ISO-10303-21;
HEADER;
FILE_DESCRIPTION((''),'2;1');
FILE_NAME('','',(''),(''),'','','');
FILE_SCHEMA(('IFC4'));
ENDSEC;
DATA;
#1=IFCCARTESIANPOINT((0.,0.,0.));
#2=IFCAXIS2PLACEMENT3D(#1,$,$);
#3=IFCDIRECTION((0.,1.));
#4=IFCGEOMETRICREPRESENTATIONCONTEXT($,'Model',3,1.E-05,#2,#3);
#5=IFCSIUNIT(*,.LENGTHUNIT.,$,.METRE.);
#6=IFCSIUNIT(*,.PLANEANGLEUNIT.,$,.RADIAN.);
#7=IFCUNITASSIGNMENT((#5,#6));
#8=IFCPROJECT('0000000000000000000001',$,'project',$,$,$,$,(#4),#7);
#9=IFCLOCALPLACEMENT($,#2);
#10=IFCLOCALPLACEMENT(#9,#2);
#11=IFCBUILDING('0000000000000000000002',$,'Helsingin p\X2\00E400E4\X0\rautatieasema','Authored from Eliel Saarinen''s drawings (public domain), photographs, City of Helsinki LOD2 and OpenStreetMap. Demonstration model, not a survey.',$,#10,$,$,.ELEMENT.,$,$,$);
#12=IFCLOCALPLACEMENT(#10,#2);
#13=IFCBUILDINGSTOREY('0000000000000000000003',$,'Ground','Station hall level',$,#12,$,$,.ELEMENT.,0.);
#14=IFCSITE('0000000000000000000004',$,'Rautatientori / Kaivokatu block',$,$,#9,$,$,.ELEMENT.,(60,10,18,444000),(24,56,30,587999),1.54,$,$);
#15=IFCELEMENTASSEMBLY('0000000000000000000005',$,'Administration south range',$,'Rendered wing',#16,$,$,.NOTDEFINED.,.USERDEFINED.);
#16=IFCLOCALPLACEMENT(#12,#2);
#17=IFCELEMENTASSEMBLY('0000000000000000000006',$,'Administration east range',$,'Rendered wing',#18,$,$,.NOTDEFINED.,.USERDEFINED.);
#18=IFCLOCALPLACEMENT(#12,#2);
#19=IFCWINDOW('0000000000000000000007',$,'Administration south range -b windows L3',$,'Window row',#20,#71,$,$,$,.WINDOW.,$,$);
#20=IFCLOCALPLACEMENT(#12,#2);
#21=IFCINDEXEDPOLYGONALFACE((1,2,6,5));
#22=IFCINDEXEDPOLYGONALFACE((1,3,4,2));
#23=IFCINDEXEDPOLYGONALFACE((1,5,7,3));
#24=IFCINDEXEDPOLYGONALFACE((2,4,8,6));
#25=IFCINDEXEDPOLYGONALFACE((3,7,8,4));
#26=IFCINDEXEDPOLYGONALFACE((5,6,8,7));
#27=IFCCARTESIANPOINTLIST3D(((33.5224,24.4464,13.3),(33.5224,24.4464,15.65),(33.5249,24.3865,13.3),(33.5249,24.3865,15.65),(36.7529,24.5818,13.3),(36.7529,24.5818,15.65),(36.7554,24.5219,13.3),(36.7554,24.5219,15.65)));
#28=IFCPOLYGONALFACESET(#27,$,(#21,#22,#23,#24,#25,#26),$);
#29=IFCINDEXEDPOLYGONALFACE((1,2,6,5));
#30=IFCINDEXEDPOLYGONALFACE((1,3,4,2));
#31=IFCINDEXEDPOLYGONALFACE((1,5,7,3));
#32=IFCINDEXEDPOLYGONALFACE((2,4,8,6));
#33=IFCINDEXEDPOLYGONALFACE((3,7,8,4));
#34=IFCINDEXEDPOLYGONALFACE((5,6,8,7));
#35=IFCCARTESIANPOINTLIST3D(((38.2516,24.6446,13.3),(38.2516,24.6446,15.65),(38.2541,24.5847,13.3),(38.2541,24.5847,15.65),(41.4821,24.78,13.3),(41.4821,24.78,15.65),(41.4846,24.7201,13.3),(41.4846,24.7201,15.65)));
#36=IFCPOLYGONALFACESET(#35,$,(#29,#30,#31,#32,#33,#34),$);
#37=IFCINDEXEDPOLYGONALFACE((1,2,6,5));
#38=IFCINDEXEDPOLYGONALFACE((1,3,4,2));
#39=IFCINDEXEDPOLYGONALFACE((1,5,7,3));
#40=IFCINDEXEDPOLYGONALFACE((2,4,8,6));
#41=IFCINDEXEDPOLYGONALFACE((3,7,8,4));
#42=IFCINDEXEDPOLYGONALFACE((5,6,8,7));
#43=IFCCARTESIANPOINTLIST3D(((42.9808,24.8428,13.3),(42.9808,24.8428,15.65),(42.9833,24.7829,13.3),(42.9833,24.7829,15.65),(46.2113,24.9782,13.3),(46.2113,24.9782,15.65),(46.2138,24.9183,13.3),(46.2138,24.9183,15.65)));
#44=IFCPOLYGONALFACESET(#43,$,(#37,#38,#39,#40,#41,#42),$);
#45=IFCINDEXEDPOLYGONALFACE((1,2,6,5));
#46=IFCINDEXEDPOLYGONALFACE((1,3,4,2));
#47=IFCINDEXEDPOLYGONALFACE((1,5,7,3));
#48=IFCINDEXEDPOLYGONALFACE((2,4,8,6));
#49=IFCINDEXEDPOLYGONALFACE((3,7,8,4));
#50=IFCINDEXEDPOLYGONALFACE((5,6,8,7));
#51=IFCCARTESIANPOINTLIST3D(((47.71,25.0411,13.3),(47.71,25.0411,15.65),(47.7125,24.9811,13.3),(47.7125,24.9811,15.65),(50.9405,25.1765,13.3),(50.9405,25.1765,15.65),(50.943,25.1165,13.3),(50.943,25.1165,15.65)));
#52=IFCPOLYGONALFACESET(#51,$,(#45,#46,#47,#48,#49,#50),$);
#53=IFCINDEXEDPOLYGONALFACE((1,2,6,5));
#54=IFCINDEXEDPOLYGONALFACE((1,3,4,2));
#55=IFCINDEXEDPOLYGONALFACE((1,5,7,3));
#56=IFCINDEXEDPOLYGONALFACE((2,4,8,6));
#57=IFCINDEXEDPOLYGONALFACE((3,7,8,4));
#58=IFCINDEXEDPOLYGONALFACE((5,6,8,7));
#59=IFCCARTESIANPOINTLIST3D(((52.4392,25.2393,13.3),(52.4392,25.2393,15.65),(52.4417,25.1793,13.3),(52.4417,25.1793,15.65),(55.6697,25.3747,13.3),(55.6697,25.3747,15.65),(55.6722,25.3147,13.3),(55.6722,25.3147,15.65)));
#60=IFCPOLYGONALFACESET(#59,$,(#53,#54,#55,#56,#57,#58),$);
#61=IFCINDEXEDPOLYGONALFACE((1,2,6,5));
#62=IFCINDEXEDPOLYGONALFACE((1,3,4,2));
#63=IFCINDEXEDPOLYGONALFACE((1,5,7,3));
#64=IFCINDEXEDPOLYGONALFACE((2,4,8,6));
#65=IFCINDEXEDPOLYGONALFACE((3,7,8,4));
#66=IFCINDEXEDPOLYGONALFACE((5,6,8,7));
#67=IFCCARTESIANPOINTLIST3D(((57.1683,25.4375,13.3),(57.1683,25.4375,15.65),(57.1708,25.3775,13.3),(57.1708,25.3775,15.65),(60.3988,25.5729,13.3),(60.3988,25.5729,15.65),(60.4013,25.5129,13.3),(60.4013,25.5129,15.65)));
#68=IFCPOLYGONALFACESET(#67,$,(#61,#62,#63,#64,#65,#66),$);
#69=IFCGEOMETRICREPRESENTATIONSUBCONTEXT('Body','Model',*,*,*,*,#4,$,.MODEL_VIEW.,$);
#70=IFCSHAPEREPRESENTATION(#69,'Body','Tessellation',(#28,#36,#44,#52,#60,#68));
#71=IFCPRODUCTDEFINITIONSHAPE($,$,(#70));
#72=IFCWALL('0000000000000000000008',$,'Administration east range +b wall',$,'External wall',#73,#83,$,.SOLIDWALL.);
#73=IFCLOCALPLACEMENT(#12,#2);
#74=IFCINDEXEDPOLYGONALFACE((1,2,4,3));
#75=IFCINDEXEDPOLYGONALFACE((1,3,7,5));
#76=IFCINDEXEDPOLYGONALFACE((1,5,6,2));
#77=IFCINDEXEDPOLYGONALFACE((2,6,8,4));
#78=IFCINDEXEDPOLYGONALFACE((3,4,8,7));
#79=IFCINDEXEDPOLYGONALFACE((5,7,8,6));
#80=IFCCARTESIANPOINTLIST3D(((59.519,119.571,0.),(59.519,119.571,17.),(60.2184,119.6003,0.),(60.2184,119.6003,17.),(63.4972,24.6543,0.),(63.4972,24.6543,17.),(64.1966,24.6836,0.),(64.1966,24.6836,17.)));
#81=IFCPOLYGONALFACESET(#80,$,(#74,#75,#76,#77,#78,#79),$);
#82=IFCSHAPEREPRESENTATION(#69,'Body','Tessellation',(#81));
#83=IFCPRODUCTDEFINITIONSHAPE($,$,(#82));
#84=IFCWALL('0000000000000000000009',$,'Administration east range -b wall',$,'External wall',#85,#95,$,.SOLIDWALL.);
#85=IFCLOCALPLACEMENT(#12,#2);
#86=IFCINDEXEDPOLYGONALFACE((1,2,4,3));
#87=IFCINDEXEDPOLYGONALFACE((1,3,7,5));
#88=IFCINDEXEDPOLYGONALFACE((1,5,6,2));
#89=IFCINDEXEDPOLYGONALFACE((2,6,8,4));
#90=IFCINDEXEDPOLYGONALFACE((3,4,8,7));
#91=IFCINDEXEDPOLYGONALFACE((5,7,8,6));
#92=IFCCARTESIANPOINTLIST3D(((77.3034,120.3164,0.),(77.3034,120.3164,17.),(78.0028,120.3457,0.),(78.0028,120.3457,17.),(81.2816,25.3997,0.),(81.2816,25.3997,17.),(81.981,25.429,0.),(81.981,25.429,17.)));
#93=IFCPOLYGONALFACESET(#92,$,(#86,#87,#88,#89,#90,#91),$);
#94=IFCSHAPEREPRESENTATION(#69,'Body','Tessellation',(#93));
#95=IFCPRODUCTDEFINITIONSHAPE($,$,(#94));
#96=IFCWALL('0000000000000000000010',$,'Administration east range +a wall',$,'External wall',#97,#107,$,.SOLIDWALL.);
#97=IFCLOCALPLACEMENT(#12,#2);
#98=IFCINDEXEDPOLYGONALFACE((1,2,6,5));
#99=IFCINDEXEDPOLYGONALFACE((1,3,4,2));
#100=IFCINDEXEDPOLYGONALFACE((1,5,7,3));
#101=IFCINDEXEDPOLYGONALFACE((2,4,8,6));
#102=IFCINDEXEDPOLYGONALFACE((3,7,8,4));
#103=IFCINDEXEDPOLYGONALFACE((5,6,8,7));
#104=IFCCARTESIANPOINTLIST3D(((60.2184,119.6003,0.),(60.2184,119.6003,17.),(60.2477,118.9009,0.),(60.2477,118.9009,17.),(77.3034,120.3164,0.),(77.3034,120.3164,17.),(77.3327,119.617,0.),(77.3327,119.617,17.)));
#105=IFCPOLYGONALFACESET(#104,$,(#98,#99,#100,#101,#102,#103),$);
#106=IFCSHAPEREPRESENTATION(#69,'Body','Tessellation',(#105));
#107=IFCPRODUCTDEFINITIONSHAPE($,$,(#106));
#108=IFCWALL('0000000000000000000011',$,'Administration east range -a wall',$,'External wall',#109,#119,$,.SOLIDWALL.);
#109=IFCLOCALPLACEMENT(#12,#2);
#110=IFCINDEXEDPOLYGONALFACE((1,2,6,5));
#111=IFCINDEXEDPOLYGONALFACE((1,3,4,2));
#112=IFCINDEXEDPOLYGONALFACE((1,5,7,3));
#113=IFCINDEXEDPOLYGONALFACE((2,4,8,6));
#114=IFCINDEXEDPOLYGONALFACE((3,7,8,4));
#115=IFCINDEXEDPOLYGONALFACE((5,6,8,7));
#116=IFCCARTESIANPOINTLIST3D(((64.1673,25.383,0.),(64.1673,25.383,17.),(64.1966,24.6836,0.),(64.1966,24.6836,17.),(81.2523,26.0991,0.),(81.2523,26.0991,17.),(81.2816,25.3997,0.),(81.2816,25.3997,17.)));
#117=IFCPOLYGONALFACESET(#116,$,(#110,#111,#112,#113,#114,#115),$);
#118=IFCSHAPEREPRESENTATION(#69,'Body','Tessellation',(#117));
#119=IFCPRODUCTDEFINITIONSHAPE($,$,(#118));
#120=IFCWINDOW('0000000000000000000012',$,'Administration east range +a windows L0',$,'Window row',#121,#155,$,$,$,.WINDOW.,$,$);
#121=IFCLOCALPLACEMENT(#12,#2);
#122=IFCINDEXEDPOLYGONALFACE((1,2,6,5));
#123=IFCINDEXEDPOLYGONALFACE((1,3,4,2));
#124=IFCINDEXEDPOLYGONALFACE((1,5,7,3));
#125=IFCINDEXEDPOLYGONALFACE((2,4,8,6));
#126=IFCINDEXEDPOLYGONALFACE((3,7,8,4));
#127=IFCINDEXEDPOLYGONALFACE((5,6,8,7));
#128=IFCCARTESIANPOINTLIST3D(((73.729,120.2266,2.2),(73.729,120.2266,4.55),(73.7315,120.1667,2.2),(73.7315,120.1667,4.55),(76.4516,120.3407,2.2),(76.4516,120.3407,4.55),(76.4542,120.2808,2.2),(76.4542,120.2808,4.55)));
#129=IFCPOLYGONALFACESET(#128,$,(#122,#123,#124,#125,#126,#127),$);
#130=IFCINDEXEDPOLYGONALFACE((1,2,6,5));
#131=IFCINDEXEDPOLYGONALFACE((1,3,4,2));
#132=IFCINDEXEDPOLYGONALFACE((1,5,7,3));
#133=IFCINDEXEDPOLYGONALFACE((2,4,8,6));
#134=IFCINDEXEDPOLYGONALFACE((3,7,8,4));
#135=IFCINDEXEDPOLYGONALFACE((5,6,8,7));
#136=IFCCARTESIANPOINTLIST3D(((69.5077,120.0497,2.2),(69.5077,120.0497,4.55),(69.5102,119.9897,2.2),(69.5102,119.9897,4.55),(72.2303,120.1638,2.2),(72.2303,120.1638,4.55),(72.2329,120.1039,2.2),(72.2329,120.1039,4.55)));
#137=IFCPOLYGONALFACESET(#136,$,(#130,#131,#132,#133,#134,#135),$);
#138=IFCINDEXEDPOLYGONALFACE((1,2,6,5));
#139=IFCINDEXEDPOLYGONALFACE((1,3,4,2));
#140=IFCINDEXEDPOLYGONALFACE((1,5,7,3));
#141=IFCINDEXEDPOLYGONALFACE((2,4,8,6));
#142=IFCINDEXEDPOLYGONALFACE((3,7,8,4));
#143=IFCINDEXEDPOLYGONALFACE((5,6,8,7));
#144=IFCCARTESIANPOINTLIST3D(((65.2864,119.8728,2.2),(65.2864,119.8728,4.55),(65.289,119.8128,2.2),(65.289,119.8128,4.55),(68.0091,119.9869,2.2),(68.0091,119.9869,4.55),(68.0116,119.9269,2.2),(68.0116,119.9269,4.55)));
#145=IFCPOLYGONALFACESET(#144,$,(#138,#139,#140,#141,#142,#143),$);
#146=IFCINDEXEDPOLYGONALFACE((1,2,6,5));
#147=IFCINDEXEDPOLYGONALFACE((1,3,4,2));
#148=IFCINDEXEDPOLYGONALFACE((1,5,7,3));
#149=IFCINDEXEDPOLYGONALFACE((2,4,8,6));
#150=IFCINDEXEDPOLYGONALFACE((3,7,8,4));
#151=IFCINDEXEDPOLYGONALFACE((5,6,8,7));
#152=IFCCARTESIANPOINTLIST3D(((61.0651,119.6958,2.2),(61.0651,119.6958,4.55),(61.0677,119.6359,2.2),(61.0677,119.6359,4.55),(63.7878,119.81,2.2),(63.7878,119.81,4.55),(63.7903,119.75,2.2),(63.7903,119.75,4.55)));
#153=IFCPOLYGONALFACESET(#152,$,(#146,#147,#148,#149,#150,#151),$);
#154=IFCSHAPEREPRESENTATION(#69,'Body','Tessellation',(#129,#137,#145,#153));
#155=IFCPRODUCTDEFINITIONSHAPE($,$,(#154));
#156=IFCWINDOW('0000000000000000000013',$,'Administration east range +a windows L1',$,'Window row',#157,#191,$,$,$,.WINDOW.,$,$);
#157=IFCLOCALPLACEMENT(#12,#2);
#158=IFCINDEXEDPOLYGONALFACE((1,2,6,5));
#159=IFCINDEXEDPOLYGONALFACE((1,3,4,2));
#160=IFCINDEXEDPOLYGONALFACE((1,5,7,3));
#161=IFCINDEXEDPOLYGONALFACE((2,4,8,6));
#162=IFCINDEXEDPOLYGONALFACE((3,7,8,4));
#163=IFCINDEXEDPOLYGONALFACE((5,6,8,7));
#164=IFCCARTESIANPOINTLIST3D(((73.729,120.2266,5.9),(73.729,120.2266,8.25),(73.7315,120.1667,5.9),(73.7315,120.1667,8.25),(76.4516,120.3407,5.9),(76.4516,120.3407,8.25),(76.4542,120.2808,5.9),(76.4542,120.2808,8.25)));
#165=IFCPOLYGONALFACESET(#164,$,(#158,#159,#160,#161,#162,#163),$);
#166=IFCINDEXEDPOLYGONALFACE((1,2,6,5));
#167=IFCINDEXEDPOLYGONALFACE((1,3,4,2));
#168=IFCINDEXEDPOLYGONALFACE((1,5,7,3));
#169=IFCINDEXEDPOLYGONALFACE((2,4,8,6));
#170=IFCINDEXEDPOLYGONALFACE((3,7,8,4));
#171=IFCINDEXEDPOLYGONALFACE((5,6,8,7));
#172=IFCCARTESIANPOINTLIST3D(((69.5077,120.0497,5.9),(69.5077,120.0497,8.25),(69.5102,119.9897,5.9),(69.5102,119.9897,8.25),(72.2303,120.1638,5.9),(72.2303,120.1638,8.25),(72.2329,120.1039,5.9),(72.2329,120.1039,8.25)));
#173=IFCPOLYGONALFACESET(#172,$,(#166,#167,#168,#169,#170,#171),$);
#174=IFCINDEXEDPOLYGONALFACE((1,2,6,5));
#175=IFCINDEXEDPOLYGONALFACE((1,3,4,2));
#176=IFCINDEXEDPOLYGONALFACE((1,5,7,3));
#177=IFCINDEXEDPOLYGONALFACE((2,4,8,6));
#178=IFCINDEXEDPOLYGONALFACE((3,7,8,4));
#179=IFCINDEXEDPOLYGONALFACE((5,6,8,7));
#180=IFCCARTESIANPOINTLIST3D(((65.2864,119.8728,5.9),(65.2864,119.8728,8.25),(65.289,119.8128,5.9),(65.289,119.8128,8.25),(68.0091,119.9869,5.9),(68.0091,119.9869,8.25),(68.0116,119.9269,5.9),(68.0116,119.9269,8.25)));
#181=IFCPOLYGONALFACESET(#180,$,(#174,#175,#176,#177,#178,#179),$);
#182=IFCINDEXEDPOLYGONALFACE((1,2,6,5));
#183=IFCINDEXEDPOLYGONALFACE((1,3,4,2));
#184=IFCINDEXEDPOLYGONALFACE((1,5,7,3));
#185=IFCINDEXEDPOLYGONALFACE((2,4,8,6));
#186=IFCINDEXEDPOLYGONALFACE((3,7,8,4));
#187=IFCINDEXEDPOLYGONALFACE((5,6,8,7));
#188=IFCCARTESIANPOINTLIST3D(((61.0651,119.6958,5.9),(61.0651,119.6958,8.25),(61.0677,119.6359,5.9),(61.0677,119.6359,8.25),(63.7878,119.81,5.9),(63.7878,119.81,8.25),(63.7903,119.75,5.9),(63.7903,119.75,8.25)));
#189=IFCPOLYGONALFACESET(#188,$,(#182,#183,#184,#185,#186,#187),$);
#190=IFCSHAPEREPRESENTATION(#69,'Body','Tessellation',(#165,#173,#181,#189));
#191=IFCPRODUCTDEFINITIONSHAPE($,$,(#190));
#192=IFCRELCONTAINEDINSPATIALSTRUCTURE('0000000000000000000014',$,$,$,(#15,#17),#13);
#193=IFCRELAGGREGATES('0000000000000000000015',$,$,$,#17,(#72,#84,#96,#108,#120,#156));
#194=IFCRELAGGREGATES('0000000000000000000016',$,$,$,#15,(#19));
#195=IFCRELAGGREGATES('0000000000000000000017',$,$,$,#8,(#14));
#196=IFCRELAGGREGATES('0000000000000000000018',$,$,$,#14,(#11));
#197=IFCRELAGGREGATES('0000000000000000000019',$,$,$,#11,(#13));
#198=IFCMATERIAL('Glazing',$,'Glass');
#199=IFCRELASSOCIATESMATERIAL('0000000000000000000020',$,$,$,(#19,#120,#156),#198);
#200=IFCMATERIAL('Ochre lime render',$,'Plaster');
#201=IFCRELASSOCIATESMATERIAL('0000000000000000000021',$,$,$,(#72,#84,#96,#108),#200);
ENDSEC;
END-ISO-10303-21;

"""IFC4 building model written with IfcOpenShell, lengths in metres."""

from ifc_helpers import new_model, si_unit, direction, frame, frame_2d, origin, place, context, subcontext, project, spatial, rectangle, extrude, material, element, aggregate, save


model = new_model("IFC4")

# Units and contexts
model_context = context("Model", 3, precision=1e-05, world=origin(), true_north=direction((0.0, 1.0)))
body_context = subcontext(model_context, "Body", "Model", "MODEL_VIEW")
ifc_project = project(units=[si_unit("LENGTHUNIT", "METRE"), si_unit("PLANEANGLEUNIT", "RADIAN")], contexts=[model_context])

# Site, building, storey
site_placement = place(None, origin())
site = spatial("IfcSite", under=ifc_project, at=site_placement, Name="Rautatientori / Kaivokatu block", CompositionType="ELEMENT", RefLatitude=(60, 10, 18, 444000), RefLongitude=(24, 56, 30, 587999), RefElevation=1.54)
building_placement = place(site_placement, origin())
building = spatial("IfcBuilding", under=site, at=building_placement, Name="Helsingin päärautatieasema", Description="Authored from Eliel Saarinen's drawings (public domain), photographs, City of Helsinki LOD2 and OpenStreetMap. Demonstration model, not a survey.", CompositionType="ELEMENT")
storey_placement = place(building_placement, origin())
storey = spatial("IfcBuildingStorey", under=building, at=storey_placement, Name="Ground", Description="Station hall level", CompositionType="ELEMENT", Elevation=0.0)

# Element assembly
assembly_1_placement = place(building_placement, origin())
assembly_1 = element("IfcElementAssembly", 1, at=assembly_1_placement, inside=storey, Name="Administration south range", ObjectType="Rendered wing", AssemblyPlace="NOTDEFINED", PredefinedType="USERDEFINED")

# Element assembly
assembly_2_placement = place(building_placement, origin())
assembly_2 = element("IfcElementAssembly", 2, at=assembly_2_placement, inside=storey, Name="Administration east range", ObjectType="Rendered wing", AssemblyPlace="NOTDEFINED", PredefinedType="USERDEFINED")

# Window
ifc_material_1 = material(Name="Glazing", Category="Glass")
window_1_placement = place(building_placement, origin())
window_1 = element("IfcWindow", 3, at=window_1_placement, material=ifc_material_1, Name="Administration south range -b windows L3", ObjectType="Window row", PredefinedType="WINDOW", context=body_context, shape_type="SweptSolid", body=[
    extrude(rectangle(XDim=3.2333, YDim=0.06, at=frame_2d((0.0, 0.0), x_axis=(0.999123, 0.041876))), frame((35.1389, 24.4841, 13.3)), (0.0, 0.0, 1.0), 2.35),
    extrude(rectangle(XDim=3.2333, YDim=0.06, at=frame_2d((0.0, 0.0), x_axis=(0.999123, 0.041876))), frame((39.8681, 24.6824, 13.3)), (0.0, 0.0, 1.0), 2.35),
    extrude(rectangle(XDim=3.2333, YDim=0.06, at=frame_2d((0.0, 0.0), x_axis=(0.999123, 0.041876))), frame((44.5973, 24.8806, 13.3)), (0.0, 0.0, 1.0), 2.35),
    extrude(rectangle(XDim=3.2333, YDim=0.06, at=frame_2d((0.0, 0.0), x_axis=(0.999123, 0.041876))), frame((49.3265, 25.0788, 13.3)), (0.0, 0.0, 1.0), 2.35),
    extrude(rectangle(XDim=3.2333, YDim=0.06, at=frame_2d((0.0, 0.0), x_axis=(0.999123, 0.041876))), frame((54.0557, 25.277, 13.3)), (0.0, 0.0, 1.0), 2.35),
    extrude(rectangle(XDim=3.2333, YDim=0.06, at=frame_2d((0.0, 0.0), x_axis=(0.999123, 0.041876))), frame((58.7848, 25.4752, 13.3)), (0.0, 0.0, 1.0), 2.35),
])

# Walls
ifc_material_2 = material(Name="Ochre lime render", Category="Plaster")
wall_1_placement = place(building_placement, origin())
wall_1 = element("IfcWall", 4, at=wall_1_placement, material=ifc_material_2, Name="Administration east range +b wall", ObjectType="External wall", PredefinedType="SOLIDWALL", context=body_context, shape_type="SweptSolid", body=[
    extrude(rectangle(XDim=95.0, YDim=0.7, at=frame_2d((0.0, 0.0), x_axis=(0.041876, -0.999123))), frame((61.8578, 72.1273, 0.0)), (0.0, 0.0, 1.0), 17.0),
])
wall_2_placement = place(building_placement, origin())
wall_2 = element("IfcWall", 5, at=wall_2_placement, material=ifc_material_2, Name="Administration east range -b wall", ObjectType="External wall", PredefinedType="SOLIDWALL", context=body_context, shape_type="SweptSolid", body=[
    extrude(rectangle(XDim=95.0, YDim=0.7, at=frame_2d((0.0, 0.0), x_axis=(-0.041876, 0.999123))), frame((79.6422, 72.8727, 0.0)), (0.0, 0.0, 1.0), 17.0),
])
wall_3_placement = place(building_placement, origin())
wall_3 = element("IfcWall", 6, at=wall_3_placement, material=ifc_material_2, Name="Administration east range +a wall", ObjectType="External wall", PredefinedType="SOLIDWALL", context=body_context, shape_type="SweptSolid", body=[
    extrude(rectangle(XDim=17.1, YDim=0.7, at=frame_2d((0.0, 0.0), x_axis=(-0.999123, -0.041876))), frame((68.7756, 119.6086, 0.0)), (0.0, 0.0, 1.0), 17.0),
])
wall_4_placement = place(building_placement, origin())
wall_4 = element("IfcWall", 7, at=wall_4_placement, material=ifc_material_2, Name="Administration east range -a wall", ObjectType="External wall", PredefinedType="SOLIDWALL", context=body_context, shape_type="SweptSolid", body=[
    extrude(rectangle(XDim=17.1, YDim=0.7, at=frame_2d((0.0, 0.0), x_axis=(0.999123, 0.041876))), frame((72.7244, 25.3914, 0.0)), (0.0, 0.0, 1.0), 17.0),
])

# Windows
window_2_placement = place(building_placement, origin())
window_2 = element("IfcWindow", 8, at=window_2_placement, material=ifc_material_1, Name="Administration east range +a windows L0", ObjectType="Window row", PredefinedType="WINDOW", context=body_context, shape_type="SweptSolid", body=[
    extrude(rectangle(XDim=2.725, YDim=0.06, at=frame_2d((0.0, 0.0), x_axis=(-0.999123, -0.041876))), frame((75.0916, 120.2537, 2.2)), (0.0, 0.0, 1.0), 2.35),
    extrude(rectangle(XDim=2.725, YDim=0.06, at=frame_2d((0.0, 0.0), x_axis=(-0.999123, -0.041876))), frame((70.8703, 120.0768, 2.2)), (0.0, 0.0, 1.0), 2.35),
    extrude(rectangle(XDim=2.725, YDim=0.06, at=frame_2d((0.0, 0.0), x_axis=(-0.999123, -0.041876))), frame((66.649, 119.8998, 2.2)), (0.0, 0.0, 1.0), 2.35),
    extrude(rectangle(XDim=2.725, YDim=0.06, at=frame_2d((0.0, 0.0), x_axis=(-0.999123, -0.041876))), frame((62.4277, 119.7229, 2.2)), (0.0, 0.0, 1.0), 2.35),
])
window_3_placement = place(building_placement, origin())
window_3 = element("IfcWindow", 9, at=window_3_placement, material=ifc_material_1, Name="Administration east range +a windows L1", ObjectType="Window row", PredefinedType="WINDOW", context=body_context, shape_type="SweptSolid", body=[
    extrude(rectangle(XDim=2.725, YDim=0.06, at=frame_2d((0.0, 0.0), x_axis=(-0.999123, -0.041876))), frame((75.0916, 120.2537, 5.9)), (0.0, 0.0, 1.0), 2.35),
    extrude(rectangle(XDim=2.725, YDim=0.06, at=frame_2d((0.0, 0.0), x_axis=(-0.999123, -0.041876))), frame((70.8703, 120.0768, 5.9)), (0.0, 0.0, 1.0), 2.35),
    extrude(rectangle(XDim=2.725, YDim=0.06, at=frame_2d((0.0, 0.0), x_axis=(-0.999123, -0.041876))), frame((66.649, 119.8998, 5.9)), (0.0, 0.0, 1.0), 2.35),
    extrude(rectangle(XDim=2.725, YDim=0.06, at=frame_2d((0.0, 0.0), x_axis=(-0.999123, -0.041876))), frame((62.4277, 119.7229, 5.9)), (0.0, 0.0, 1.0), 2.35),
])
aggregate(assembly_2, [wall_1, wall_2, wall_3, wall_4, window_2, window_3])

aggregate(assembly_1, [window_1])

save(model, "model.ifc")
